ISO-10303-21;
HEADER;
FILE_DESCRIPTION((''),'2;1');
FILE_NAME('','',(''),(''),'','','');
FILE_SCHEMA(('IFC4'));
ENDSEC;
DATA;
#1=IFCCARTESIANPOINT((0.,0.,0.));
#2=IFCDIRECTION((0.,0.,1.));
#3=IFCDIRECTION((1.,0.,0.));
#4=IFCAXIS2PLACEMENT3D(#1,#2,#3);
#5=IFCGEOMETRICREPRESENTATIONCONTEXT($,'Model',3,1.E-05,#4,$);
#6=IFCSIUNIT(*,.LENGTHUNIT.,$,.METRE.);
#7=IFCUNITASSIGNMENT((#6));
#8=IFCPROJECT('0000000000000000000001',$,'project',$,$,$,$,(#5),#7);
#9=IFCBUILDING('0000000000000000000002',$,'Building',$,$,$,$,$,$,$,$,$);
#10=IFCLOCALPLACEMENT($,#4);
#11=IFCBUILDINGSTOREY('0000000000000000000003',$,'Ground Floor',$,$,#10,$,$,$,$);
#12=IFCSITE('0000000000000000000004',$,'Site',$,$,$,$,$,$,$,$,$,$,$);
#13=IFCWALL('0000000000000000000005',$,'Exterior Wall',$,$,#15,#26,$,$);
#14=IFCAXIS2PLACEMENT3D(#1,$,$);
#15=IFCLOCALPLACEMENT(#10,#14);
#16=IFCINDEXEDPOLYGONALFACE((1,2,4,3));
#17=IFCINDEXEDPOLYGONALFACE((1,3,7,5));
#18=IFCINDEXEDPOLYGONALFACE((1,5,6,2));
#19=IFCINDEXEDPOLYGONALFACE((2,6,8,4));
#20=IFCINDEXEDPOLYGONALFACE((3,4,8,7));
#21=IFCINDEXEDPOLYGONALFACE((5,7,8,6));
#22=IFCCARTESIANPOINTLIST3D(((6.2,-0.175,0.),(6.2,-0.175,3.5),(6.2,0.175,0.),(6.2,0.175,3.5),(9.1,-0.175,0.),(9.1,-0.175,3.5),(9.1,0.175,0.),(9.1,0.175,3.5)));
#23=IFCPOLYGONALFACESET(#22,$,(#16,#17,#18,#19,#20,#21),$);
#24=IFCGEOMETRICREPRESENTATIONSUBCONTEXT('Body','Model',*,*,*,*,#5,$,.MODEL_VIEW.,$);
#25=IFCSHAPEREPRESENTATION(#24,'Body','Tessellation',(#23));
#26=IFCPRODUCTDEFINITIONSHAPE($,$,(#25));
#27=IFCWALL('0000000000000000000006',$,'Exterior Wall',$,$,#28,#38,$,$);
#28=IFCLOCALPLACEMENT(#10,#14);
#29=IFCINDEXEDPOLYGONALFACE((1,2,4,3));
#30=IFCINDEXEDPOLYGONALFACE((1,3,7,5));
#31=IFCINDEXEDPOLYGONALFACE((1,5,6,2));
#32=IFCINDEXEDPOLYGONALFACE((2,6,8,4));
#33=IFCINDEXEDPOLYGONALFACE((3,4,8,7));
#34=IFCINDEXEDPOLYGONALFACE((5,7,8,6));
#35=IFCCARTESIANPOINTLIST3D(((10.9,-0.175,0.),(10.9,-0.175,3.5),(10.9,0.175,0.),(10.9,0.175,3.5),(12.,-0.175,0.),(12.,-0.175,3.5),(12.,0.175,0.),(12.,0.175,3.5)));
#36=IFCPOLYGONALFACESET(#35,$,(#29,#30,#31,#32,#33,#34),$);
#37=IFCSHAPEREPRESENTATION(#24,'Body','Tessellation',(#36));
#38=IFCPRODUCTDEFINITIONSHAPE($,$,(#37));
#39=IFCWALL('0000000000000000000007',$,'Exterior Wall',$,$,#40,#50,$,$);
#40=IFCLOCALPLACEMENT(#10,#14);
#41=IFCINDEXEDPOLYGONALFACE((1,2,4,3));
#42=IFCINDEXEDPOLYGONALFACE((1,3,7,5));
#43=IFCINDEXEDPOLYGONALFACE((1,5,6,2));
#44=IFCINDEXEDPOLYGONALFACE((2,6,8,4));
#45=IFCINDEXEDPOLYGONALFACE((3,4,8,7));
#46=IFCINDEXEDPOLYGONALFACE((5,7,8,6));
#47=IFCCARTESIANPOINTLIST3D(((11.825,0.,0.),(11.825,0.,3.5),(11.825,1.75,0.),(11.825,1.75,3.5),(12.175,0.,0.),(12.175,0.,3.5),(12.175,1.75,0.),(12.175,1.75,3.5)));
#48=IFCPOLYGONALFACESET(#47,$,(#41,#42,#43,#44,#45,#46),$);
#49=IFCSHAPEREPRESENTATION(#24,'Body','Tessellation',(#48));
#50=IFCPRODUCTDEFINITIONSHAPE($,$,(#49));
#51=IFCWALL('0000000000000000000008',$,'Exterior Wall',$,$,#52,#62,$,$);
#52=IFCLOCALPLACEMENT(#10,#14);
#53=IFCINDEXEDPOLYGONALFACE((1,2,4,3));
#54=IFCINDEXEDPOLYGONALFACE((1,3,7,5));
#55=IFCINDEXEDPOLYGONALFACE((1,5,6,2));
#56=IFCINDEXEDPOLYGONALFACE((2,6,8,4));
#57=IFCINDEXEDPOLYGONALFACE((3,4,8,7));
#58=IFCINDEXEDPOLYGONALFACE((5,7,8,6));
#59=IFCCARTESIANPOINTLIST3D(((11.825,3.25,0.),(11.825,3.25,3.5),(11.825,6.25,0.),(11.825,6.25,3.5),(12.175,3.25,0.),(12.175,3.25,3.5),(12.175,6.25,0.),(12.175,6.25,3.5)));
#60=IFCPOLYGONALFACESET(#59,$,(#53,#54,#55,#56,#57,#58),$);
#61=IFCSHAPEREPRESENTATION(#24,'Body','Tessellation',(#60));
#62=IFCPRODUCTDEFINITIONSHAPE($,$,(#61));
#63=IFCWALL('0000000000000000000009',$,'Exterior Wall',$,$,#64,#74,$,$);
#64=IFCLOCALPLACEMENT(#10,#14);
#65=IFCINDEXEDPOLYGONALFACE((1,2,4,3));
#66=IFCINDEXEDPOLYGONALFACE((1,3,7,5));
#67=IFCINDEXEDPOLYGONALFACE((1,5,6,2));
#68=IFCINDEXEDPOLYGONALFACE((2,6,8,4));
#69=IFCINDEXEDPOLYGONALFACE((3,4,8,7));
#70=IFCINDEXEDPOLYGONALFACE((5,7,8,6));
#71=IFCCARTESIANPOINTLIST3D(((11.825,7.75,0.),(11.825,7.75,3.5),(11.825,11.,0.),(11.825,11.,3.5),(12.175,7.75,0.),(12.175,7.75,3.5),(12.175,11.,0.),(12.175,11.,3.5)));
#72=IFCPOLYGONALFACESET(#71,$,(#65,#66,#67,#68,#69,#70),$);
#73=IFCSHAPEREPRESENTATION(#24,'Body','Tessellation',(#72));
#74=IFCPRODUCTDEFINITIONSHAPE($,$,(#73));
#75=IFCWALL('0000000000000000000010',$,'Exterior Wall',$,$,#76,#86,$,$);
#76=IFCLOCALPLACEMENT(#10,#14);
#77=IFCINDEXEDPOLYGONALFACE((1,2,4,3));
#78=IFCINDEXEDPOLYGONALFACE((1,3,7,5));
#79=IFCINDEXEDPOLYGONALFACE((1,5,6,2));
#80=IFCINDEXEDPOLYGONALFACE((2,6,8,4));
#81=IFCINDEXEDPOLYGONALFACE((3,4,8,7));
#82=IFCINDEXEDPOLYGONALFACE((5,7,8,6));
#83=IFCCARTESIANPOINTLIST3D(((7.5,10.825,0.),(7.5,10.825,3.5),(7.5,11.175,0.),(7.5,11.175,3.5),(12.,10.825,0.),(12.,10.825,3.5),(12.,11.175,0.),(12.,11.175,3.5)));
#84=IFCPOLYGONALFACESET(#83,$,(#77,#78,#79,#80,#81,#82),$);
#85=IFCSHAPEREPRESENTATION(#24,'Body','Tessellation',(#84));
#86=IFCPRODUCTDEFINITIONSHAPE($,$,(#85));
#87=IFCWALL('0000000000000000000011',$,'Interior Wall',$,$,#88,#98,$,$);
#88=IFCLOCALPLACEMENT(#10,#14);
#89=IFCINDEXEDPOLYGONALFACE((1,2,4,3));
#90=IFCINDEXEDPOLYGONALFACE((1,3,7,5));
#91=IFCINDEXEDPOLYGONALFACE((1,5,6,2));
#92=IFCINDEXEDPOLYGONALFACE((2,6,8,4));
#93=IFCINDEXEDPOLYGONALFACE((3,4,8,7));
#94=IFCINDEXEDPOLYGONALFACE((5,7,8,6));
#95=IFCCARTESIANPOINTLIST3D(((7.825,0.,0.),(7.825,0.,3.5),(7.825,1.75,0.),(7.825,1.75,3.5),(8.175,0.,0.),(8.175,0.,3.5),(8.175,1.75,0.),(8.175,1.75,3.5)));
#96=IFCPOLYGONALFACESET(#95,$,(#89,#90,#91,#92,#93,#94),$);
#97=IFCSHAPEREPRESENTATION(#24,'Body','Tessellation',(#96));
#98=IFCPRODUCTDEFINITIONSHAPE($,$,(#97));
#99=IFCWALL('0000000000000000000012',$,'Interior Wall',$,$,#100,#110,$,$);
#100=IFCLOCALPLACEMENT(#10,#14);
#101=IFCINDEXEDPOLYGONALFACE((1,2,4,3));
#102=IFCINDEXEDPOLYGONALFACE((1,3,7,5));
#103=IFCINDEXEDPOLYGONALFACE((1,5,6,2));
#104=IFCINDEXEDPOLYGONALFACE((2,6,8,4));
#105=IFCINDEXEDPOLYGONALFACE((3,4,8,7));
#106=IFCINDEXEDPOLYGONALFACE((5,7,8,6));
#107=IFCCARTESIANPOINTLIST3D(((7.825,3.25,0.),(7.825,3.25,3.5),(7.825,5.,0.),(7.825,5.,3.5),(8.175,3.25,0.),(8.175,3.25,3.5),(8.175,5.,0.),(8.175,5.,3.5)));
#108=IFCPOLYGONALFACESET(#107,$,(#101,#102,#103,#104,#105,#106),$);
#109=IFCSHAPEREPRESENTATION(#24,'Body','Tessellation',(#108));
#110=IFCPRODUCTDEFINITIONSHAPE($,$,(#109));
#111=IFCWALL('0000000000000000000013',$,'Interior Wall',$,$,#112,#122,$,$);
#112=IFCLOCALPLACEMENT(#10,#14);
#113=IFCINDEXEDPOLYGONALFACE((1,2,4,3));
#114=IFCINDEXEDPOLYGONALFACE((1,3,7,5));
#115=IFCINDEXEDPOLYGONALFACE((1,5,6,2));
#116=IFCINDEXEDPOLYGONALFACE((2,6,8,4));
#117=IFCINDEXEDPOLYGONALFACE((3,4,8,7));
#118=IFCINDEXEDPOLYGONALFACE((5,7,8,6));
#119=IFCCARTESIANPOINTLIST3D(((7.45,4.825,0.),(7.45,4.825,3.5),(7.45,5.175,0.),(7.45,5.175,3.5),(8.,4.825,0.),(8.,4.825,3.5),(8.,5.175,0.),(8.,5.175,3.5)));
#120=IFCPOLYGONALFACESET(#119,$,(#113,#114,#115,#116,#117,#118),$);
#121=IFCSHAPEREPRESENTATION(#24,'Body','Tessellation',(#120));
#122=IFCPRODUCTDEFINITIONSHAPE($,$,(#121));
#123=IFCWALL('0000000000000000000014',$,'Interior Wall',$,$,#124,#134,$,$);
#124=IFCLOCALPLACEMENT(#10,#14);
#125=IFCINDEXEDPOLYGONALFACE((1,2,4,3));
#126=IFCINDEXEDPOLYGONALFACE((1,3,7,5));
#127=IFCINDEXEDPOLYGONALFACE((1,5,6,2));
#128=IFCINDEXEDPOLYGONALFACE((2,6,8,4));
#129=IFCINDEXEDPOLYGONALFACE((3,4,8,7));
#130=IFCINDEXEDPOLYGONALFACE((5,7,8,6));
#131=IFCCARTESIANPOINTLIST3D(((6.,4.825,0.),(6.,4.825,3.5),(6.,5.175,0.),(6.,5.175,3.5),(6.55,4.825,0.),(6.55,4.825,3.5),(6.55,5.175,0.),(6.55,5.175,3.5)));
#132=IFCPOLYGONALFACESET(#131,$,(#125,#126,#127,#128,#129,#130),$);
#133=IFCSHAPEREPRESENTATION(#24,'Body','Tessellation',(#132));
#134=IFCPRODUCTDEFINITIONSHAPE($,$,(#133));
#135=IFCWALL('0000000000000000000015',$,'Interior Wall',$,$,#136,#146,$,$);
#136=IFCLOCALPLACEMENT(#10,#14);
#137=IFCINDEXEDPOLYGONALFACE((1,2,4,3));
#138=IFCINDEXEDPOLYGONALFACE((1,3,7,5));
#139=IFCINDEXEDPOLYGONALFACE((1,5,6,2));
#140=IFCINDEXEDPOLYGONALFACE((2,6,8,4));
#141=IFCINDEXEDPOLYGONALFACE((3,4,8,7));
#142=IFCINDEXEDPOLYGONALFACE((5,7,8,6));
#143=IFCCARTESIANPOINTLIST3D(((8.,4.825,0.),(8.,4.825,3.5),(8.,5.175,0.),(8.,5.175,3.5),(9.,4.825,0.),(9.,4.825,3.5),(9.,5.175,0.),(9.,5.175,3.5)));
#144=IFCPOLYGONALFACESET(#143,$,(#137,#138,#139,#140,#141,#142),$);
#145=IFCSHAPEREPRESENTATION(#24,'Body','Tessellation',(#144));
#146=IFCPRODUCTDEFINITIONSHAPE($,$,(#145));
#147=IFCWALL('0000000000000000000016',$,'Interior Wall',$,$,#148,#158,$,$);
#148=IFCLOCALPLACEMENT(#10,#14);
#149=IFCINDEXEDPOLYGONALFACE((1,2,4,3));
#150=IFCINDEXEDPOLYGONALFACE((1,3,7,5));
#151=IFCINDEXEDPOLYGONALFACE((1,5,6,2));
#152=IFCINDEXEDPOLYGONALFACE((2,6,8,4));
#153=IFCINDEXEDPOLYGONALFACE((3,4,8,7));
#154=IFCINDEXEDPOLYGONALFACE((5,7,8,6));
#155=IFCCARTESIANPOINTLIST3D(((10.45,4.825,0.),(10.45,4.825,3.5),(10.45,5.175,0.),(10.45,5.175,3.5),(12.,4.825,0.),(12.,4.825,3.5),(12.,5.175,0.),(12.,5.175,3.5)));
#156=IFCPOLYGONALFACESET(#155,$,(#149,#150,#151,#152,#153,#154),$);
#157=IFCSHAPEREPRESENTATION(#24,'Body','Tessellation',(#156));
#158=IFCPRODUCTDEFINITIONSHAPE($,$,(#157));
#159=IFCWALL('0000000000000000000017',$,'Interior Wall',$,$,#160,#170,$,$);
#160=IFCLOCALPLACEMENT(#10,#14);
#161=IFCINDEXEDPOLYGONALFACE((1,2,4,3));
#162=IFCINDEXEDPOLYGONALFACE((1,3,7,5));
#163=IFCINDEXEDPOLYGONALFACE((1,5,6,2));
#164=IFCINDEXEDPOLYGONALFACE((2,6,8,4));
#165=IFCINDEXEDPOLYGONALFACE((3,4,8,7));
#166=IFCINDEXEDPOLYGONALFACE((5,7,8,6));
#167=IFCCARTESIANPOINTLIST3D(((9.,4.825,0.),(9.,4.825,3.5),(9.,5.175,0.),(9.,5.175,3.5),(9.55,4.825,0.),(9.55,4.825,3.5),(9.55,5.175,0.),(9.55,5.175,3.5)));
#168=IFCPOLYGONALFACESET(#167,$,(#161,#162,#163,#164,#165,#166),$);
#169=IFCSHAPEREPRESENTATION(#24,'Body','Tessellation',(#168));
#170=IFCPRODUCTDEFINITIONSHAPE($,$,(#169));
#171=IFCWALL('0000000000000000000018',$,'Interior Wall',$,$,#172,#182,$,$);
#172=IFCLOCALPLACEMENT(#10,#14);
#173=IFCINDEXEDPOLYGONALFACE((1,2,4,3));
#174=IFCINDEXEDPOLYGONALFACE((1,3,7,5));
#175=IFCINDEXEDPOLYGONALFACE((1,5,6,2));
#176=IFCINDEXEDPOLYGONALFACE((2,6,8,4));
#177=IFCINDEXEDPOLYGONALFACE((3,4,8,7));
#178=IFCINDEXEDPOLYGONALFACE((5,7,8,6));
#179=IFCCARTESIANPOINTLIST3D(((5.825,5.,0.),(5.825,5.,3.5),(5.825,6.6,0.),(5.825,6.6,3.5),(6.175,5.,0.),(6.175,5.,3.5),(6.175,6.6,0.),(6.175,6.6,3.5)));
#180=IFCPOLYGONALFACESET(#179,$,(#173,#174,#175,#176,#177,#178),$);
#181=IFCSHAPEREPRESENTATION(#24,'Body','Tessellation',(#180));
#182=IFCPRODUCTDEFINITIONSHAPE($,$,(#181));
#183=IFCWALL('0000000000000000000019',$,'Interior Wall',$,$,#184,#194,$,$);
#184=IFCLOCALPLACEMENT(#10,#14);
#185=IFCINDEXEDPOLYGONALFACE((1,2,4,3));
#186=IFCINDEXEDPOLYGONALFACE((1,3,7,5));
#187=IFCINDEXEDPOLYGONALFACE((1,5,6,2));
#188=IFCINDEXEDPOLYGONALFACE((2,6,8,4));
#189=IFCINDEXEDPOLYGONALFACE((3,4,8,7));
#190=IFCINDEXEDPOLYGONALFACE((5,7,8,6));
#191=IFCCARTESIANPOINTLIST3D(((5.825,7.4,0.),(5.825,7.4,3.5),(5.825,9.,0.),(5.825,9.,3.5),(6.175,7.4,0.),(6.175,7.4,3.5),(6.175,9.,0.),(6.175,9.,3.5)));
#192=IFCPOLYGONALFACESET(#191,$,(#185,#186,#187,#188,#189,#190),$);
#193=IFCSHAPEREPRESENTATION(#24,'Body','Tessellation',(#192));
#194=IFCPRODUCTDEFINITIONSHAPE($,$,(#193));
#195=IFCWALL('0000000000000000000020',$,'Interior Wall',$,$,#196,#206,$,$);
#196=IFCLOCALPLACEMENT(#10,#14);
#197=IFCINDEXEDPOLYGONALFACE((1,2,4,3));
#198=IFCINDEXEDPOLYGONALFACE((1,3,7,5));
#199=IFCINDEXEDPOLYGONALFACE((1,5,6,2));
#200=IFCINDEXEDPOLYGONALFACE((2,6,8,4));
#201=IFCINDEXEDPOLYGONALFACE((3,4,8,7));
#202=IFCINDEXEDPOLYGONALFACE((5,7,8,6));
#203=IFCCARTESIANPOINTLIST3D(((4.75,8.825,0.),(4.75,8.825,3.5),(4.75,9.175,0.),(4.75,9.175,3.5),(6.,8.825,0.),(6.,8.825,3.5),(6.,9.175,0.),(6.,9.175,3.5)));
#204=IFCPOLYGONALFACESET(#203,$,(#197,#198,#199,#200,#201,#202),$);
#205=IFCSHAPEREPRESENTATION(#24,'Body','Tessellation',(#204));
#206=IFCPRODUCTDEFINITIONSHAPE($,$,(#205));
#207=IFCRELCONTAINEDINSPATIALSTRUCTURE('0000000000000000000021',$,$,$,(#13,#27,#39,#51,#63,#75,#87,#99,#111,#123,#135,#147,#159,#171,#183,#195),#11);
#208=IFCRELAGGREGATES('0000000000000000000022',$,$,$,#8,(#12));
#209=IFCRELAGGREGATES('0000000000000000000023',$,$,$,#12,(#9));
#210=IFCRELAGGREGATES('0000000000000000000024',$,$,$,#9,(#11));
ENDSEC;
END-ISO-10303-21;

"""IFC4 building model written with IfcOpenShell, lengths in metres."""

from ifc_helpers import new_model, si_unit, frame, origin_with_axes, place, context, subcontext, project, spatial, indexed_curve, outline, extrude, element, save


model = new_model("IFC4")

# Units and contexts
model_context = context("Model", 3, precision=1e-05, world=origin_with_axes())
body_context = subcontext(model_context, "Body", "Model", "MODEL_VIEW")
ifc_project = project(units=[si_unit("LENGTHUNIT", "METRE")], contexts=[model_context])

# Site, building, storey
site = spatial("IfcSite", under=ifc_project, Name="Site")
building = spatial("IfcBuilding", under=site, Name="Building")
storey_placement = place(None, origin_with_axes())
storey = spatial("IfcBuildingStorey", under=building, at=storey_placement, Name="Ground Floor")

# Walls
wall_1_placement = place(storey_placement, frame((6.2, 0.0, 0.0), z_axis=(0.0, 0.0, 1.0), x_axis=(1.0, 0.0, 0.0)))
element("IfcWall", 1, at=wall_1_placement, inside=storey, Name="Exterior Wall", context=body_context, shape_type="SweptSolid", body=[
    extrude(outline(indexed_curve([(0.0, 0.0), (0.0, 0.35), (2.9, 0.35), (2.9, 0.0), (0.0, 0.0)], self_intersect=False)), frame((0.0, -0.175, 0.0), z_axis=(0.0, 0.0, 1.0), x_axis=(1.0, 0.0, 0.0)), (0.0, 0.0, 1.0), 3.5),
])
wall_2_placement = place(storey_placement, frame((10.9, 0.0, 0.0), z_axis=(0.0, 0.0, 1.0), x_axis=(1.0, 0.0, 0.0)))
element("IfcWall", 2, at=wall_2_placement, inside=storey, Name="Exterior Wall", context=body_context, shape_type="SweptSolid", body=[
    extrude(outline(indexed_curve([(0.0, 0.0), (0.0, 0.35), (1.1, 0.35), (1.1, 0.0), (0.0, 0.0)], self_intersect=False)), frame((0.0, -0.175, 0.0), z_axis=(0.0, 0.0, 1.0), x_axis=(1.0, 0.0, 0.0)), (0.0, 0.0, 1.0), 3.5),
])
wall_3_placement = place(storey_placement, frame((12.0, 0.0, 0.0), z_axis=(0.0, 0.0, 1.0), x_axis=(0.0, 1.0, 0.0)))
element("IfcWall", 3, at=wall_3_placement, inside=storey, Name="Exterior Wall", context=body_context, shape_type="SweptSolid", body=[
    extrude(outline(indexed_curve([(0.0, 0.0), (0.0, 0.35), (1.75, 0.35), (1.75, 0.0), (0.0, 0.0)], self_intersect=False)), frame((0.0, -0.175, 0.0), z_axis=(0.0, 0.0, 1.0), x_axis=(1.0, 0.0, 0.0)), (0.0, 0.0, 1.0), 3.5),
])
wall_4_placement = place(storey_placement, frame((12.0, 3.25, 0.0), z_axis=(0.0, 0.0, 1.0), x_axis=(0.0, 1.0, 0.0)))
element("IfcWall", 4, at=wall_4_placement, inside=storey, Name="Exterior Wall", context=body_context, shape_type="SweptSolid", body=[
    extrude(outline(indexed_curve([(0.0, 0.0), (0.0, 0.35), (3.0, 0.35), (3.0, 0.0), (0.0, 0.0)], self_intersect=False)), frame((0.0, -0.175, 0.0), z_axis=(0.0, 0.0, 1.0), x_axis=(1.0, 0.0, 0.0)), (0.0, 0.0, 1.0), 3.5),
])
wall_5_placement = place(storey_placement, frame((12.0, 7.75, 0.0), z_axis=(0.0, 0.0, 1.0), x_axis=(0.0, 1.0, 0.0)))
element("IfcWall", 5, at=wall_5_placement, inside=storey, Name="Exterior Wall", context=body_context, shape_type="SweptSolid", body=[
    extrude(outline(indexed_curve([(0.0, 0.0), (0.0, 0.35), (3.25, 0.35), (3.25, 0.0), (0.0, 0.0)], self_intersect=False)), frame((0.0, -0.175, 0.0), z_axis=(0.0, 0.0, 1.0), x_axis=(1.0, 0.0, 0.0)), (0.0, 0.0, 1.0), 3.5),
])
wall_6_placement = place(storey_placement, frame((12.0, 11.0, 0.0), z_axis=(0.0, 0.0, 1.0), x_axis=(-1.0, 0.0, 0.0)))
element("IfcWall", 6, at=wall_6_placement, inside=storey, Name="Exterior Wall", context=body_context, shape_type="SweptSolid", body=[
    extrude(outline(indexed_curve([(0.0, 0.0), (0.0, 0.35), (4.5, 0.35), (4.5, 0.0), (0.0, 0.0)], self_intersect=False)), frame((0.0, -0.175, 0.0), z_axis=(0.0, 0.0, 1.0), x_axis=(1.0, 0.0, 0.0)), (0.0, 0.0, 1.0), 3.5),
])
for number, where, z_axis, x_axis, name in (
    (7, (8.0, 0.0, 0.0), (0.0, 0.0, 1.0), (0.0, 1.0, 0.0), "Interior Wall"),
    (8, (8.0, 3.25, 0.0), (0.0, 0.0, 1.0), (0.0, 1.0, 0.0), "Interior Wall"),
):
    element("IfcWall", number, at=place(storey_placement, frame(where, z_axis=z_axis, x_axis=x_axis)), inside=storey, Name=name, context=body_context, shape_type="SweptSolid", body=[
        extrude(outline(indexed_curve([(0.0, 0.0), (0.0, 0.35), (1.75, 0.35), (1.75, 0.0), (0.0, 0.0)], self_intersect=False)), frame((0.0, -0.175, 0.0), z_axis=(0.0, 0.0, 1.0), x_axis=(1.0, 0.0, 0.0)), (0.0, 0.0, 1.0), 3.5),
    ])
for number, where, z_axis, x_axis, name in (
    (9, (8.0, 5.0, 0.0), (0.0, 0.0, 1.0), (-1.0, 0.0, 0.0), "Interior Wall"),
    (10, (6.55, 5.0, 0.0), (0.0, 0.0, 1.0), (-1.0, 0.0, 0.0), "Interior Wall"),
):
    element("IfcWall", number, at=place(storey_placement, frame(where, z_axis=z_axis, x_axis=x_axis)), inside=storey, Name=name, context=body_context, shape_type="SweptSolid", body=[
        extrude(outline(indexed_curve([(0.0, 0.0), (0.0, 0.35), (0.55, 0.35), (0.55, 0.0), (0.0, 0.0)], self_intersect=False)), frame((0.0, -0.175, 0.0), z_axis=(0.0, 0.0, 1.0), x_axis=(1.0, 0.0, 0.0)), (0.0, 0.0, 1.0), 3.5),
    ])
wall_7_placement = place(storey_placement, frame((9.0, 5.0, 0.0), z_axis=(0.0, 0.0, 1.0), x_axis=(-1.0, 0.0, 0.0)))
element("IfcWall", 11, at=wall_7_placement, inside=storey, Name="Interior Wall", context=body_context, shape_type="SweptSolid", body=[
    extrude(outline(indexed_curve([(0.0, 0.0), (0.0, 0.35), (1.0, 0.35), (1.0, 0.0), (0.0, 0.0)], self_intersect=False)), frame((0.0, -0.175, 0.0), z_axis=(0.0, 0.0, 1.0), x_axis=(1.0, 0.0, 0.0)), (0.0, 0.0, 1.0), 3.5),
])
wall_8_placement = place(storey_placement, frame((12.0, 5.0, 0.0), z_axis=(0.0, 0.0, 1.0), x_axis=(-1.0, 0.0, 0.0)))
element("IfcWall", 12, at=wall_8_placement, inside=storey, Name="Interior Wall", context=body_context, shape_type="SweptSolid", body=[
    extrude(outline(indexed_curve([(0.0, 0.0), (0.0, 0.35), (1.55, 0.35), (1.55, 0.0), (0.0, 0.0)], self_intersect=False)), frame((0.0, -0.175, 0.0), z_axis=(0.0, 0.0, 1.0), x_axis=(1.0, 0.0, 0.0)), (0.0, 0.0, 1.0), 3.5),
])
wall_9_placement = place(storey_placement, frame((9.55, 5.0, 0.0), z_axis=(0.0, 0.0, 1.0), x_axis=(-1.0, 0.0, 0.0)))
element("IfcWall", 13, at=wall_9_placement, inside=storey, Name="Interior Wall", context=body_context, shape_type="SweptSolid", body=[
    extrude(outline(indexed_curve([(0.0, 0.0), (0.0, 0.35), (0.55, 0.35), (0.55, 0.0), (0.0, 0.0)], self_intersect=False)), frame((0.0, -0.175, 0.0), z_axis=(0.0, 0.0, 1.0), x_axis=(1.0, 0.0, 0.0)), (0.0, 0.0, 1.0), 3.5),
])
for number, where, z_axis, x_axis, name in (
    (14, (6.0, 5.0, 0.0), (0.0, 0.0, 1.0), (0.0, 1.0, 0.0), "Interior Wall"),
    (15, (6.0, 7.4, 0.0), (0.0, 0.0, 1.0), (0.0, 1.0, 0.0), "Interior Wall"),
):
    element("IfcWall", number, at=place(storey_placement, frame(where, z_axis=z_axis, x_axis=x_axis)), inside=storey, Name=name, context=body_context, shape_type="SweptSolid", body=[
        extrude(outline(indexed_curve([(0.0, 0.0), (0.0, 0.35), (1.6, 0.35), (1.6, 0.0), (0.0, 0.0)], self_intersect=False)), frame((0.0, -0.175, 0.0), z_axis=(0.0, 0.0, 1.0), x_axis=(1.0, 0.0, 0.0)), (0.0, 0.0, 1.0), 3.5),
    ])
wall_10_placement = place(storey_placement, frame((6.0, 9.0, 0.0), z_axis=(0.0, 0.0, 1.0), x_axis=(-1.0, 0.0, 0.0)))
element("IfcWall", 16, at=wall_10_placement, inside=storey, Name="Interior Wall", context=body_context, shape_type="SweptSolid", body=[
    extrude(outline(indexed_curve([(0.0, 0.0), (0.0, 0.35), (1.25, 0.35), (1.25, 0.0), (0.0, 0.0)], self_intersect=False)), frame((0.0, -0.175, 0.0), z_axis=(0.0, 0.0, 1.0), x_axis=(1.0, 0.0, 0.0)), (0.0, 0.0, 1.0), 3.5),
])

save(model, "model.ifc")
